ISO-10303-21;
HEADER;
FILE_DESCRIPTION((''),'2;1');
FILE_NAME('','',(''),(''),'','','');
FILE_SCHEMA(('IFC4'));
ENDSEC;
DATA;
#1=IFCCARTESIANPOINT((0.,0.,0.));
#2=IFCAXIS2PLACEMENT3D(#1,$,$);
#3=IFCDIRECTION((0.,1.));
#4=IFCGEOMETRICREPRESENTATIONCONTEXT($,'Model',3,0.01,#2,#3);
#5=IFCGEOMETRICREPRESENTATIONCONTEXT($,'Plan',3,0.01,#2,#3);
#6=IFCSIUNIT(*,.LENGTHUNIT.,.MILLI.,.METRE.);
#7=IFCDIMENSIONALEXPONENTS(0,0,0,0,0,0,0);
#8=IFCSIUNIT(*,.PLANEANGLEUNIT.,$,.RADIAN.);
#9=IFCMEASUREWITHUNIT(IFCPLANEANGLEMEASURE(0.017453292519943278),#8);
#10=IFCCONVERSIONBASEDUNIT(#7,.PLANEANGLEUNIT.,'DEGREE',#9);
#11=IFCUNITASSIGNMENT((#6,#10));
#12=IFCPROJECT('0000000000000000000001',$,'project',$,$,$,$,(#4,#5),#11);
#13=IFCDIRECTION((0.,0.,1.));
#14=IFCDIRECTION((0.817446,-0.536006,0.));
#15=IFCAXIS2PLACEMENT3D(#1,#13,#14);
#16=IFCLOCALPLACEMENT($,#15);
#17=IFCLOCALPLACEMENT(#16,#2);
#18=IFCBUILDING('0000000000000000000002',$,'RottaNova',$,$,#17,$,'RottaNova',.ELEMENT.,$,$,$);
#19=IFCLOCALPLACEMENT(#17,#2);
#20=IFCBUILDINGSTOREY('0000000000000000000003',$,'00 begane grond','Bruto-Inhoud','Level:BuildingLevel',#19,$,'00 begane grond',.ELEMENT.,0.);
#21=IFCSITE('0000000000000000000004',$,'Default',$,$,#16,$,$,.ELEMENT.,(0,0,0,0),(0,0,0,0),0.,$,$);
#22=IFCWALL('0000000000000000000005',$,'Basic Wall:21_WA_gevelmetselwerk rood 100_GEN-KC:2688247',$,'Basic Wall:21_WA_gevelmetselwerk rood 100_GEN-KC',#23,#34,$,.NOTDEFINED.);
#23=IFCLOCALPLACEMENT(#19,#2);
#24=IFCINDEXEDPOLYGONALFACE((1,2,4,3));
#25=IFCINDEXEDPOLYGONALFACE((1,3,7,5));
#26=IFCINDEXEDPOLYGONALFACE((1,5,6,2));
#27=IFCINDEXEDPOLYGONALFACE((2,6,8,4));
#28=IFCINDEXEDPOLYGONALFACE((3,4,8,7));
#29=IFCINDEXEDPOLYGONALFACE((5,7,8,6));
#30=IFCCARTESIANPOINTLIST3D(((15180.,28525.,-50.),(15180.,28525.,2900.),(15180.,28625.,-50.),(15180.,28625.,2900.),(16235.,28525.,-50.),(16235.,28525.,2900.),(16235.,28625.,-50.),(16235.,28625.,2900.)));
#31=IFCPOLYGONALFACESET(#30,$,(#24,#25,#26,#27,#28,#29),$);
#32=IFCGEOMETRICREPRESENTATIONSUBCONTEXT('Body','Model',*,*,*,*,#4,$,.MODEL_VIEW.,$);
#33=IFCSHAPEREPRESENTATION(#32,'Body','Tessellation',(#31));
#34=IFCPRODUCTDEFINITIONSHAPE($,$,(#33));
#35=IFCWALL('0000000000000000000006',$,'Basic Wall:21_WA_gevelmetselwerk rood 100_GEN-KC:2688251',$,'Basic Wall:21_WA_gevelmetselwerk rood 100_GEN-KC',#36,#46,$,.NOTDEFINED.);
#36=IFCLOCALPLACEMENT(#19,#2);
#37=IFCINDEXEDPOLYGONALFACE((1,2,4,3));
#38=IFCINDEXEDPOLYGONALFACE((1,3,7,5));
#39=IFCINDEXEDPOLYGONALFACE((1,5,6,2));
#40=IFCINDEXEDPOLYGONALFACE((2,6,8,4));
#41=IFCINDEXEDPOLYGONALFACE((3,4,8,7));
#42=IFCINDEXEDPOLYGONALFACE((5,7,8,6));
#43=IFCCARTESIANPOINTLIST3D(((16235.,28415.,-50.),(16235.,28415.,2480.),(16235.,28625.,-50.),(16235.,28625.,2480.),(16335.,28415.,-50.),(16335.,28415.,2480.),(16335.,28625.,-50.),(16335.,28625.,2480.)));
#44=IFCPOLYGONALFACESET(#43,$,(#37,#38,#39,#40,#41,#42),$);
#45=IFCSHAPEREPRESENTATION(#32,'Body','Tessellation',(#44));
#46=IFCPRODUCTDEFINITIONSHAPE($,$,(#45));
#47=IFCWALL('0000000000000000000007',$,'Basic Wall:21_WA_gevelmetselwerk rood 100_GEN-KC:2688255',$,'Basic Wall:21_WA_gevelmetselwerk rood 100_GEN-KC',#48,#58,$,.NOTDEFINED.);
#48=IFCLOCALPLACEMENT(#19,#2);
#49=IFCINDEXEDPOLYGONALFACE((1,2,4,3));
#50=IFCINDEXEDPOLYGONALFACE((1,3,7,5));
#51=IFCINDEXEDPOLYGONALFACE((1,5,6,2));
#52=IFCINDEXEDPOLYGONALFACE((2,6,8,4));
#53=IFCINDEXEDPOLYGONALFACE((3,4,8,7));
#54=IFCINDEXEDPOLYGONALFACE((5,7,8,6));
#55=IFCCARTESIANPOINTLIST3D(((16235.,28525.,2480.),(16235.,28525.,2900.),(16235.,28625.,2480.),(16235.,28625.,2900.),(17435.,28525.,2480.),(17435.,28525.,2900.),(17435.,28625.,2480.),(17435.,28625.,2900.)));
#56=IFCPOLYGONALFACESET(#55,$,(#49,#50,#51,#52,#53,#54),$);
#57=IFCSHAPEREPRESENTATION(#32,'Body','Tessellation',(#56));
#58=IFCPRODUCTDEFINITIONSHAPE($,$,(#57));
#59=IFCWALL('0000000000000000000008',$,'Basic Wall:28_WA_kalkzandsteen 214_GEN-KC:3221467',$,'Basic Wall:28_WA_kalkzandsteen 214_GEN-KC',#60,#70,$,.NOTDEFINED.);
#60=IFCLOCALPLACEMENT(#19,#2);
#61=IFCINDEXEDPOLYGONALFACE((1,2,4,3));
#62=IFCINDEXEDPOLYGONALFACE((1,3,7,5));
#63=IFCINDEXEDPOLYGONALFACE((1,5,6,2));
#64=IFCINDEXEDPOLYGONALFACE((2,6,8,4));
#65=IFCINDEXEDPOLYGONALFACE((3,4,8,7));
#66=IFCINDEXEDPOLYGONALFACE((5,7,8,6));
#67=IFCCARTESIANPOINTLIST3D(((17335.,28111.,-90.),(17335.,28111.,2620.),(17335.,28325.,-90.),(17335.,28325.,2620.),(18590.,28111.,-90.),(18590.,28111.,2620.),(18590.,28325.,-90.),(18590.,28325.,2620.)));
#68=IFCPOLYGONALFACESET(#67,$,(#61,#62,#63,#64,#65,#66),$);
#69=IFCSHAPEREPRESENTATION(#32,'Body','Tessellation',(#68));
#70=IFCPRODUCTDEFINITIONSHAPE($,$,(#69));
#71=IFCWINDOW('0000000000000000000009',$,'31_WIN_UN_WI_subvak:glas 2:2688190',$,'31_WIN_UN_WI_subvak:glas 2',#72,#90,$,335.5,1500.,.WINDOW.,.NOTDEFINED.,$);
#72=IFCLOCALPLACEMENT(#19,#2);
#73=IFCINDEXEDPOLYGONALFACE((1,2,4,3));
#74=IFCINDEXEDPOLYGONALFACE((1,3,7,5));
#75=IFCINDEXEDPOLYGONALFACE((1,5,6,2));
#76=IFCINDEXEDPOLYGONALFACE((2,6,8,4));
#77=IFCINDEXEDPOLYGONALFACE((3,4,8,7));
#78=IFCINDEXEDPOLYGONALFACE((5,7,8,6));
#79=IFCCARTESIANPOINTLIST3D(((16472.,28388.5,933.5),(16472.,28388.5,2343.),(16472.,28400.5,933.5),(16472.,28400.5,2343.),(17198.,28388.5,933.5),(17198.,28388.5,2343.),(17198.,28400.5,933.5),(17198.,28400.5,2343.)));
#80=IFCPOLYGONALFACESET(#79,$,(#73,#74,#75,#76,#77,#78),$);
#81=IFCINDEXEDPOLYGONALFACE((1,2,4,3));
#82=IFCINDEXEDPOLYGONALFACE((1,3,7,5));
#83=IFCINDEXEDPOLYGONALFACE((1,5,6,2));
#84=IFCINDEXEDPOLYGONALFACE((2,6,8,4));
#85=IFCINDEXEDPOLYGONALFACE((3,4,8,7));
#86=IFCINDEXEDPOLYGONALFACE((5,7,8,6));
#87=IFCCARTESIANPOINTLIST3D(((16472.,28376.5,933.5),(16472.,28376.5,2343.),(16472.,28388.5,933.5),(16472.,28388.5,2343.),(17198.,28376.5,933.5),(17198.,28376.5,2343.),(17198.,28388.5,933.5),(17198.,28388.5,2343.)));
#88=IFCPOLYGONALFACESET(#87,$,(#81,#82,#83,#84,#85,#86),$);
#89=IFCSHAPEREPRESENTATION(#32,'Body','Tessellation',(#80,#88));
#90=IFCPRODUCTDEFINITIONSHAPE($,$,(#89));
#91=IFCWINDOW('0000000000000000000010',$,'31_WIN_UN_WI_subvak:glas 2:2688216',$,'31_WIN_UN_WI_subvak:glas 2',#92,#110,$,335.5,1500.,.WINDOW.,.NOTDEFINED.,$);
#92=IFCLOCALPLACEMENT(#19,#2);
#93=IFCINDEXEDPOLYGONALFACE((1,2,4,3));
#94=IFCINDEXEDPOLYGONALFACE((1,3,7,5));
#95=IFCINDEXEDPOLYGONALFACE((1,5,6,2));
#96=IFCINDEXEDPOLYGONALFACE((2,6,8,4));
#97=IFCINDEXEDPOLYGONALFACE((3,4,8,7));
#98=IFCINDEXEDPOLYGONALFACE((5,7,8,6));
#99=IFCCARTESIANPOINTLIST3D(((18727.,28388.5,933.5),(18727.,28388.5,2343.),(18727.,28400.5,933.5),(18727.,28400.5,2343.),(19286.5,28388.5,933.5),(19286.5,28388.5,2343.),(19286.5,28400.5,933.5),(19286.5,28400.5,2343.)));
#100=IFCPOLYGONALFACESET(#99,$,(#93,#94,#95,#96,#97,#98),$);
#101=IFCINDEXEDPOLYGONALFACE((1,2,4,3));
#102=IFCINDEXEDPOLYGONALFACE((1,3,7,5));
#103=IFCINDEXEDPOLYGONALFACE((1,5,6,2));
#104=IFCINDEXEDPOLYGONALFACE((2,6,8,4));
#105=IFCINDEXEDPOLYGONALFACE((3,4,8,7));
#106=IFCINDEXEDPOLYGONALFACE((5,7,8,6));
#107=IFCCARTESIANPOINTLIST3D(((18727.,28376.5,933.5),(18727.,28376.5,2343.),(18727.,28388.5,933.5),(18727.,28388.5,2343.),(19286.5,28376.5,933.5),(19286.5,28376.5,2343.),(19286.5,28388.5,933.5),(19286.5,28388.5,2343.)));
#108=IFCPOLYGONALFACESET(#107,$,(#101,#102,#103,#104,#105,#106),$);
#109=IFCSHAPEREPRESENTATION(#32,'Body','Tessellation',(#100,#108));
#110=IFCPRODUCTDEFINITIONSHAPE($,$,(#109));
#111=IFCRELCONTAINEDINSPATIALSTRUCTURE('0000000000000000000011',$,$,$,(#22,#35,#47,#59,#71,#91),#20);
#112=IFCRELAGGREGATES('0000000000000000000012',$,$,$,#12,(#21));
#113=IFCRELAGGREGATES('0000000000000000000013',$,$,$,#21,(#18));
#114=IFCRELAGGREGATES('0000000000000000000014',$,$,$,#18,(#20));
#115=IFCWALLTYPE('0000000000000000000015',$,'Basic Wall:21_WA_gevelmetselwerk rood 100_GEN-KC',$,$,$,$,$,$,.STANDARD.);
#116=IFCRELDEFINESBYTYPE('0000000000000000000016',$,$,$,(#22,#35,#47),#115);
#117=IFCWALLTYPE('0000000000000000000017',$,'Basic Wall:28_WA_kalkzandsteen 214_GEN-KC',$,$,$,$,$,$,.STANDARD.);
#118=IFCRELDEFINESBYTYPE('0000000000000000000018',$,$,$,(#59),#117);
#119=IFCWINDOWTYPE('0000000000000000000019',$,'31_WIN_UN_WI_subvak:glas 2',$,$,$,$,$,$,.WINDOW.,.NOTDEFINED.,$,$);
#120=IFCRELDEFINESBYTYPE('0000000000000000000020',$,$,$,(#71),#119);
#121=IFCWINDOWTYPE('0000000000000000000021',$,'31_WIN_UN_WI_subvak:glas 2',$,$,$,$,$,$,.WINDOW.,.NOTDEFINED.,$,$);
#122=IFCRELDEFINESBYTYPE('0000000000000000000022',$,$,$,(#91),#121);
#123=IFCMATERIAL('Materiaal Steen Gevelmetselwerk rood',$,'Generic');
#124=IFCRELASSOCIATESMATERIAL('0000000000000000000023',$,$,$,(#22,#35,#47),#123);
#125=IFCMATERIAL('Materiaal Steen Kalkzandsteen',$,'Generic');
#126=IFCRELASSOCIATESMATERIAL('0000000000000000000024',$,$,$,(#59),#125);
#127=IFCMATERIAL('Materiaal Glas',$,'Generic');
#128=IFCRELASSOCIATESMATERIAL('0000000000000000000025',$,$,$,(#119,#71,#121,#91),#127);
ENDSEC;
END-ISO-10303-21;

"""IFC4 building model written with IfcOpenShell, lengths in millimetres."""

from ifc_helpers import new_model, entity, si_unit, converted_unit, direction, frame, origin, place, context, subcontext, project, spatial, indexed_curve, outline, extrude, source, transform, mapped, material, type_object, type_shapes, element, save


model = new_model("IFC4")

# Units and contexts
model_context = context("Model", 3, precision=0.01, world=origin(), true_north=direction((0.0, 1.0)))
plan_context = context("Plan", 3, precision=0.01, world=origin(), true_north=direction((0.0, 1.0)))
body_context = subcontext(model_context, "Body", "Model", "MODEL_VIEW")
ifc_project = project(units=[si_unit("LENGTHUNIT", "METRE", prefix="MILLI"), converted_unit("PLANEANGLEUNIT", "DEGREE", entity("IfcPlaneAngleMeasure", 0.017453292519943278), si_unit("PLANEANGLEUNIT", "RADIAN"), dimensions=[0, 0, 0, 0, 0, 0, 0])], contexts=[model_context, plan_context])

# Site, building, storey
site_placement = place(None, frame((0.0, 0.0, 0.0), z_axis=(0.0, 0.0, 1.0), x_axis=(0.817446, -0.536006, 0.0)))
site = spatial("IfcSite", under=ifc_project, at=site_placement, Name="Default", CompositionType="ELEMENT", RefLatitude=(0, 0, 0, 0), RefLongitude=(0, 0, 0, 0), RefElevation=0.0)
building_placement = place(site_placement, origin())
building = spatial("IfcBuilding", under=site, at=building_placement, Name="RottaNova", LongName="RottaNova", CompositionType="ELEMENT")
storey_placement = place(building_placement, origin())
storey = spatial("IfcBuildingStorey", under=building, at=storey_placement, Name="00 begane grond", Description="Bruto-Inhoud", ObjectType="Level:BuildingLevel", LongName="00 begane grond", CompositionType="ELEMENT", Elevation=0.0)

# Shared definitions
ifc_material_1 = material(Name="Materiaal Glas", Category="Generic")

# Walls
ifc_material_2 = material(Name="Materiaal Steen Gevelmetselwerk rood", Category="Generic")
wall_type_1 = type_object("IfcWallType", Name="Basic Wall:21_WA_gevelmetselwerk rood 100_GEN-KC", PredefinedType="STANDARD")
wall_1_placement = place(storey_placement, frame((16235.0, 28575.0, -50.0), z_axis=(0.0, 0.0, 1.0), x_axis=(-1.0, 0.0, 0.0)))
element("IfcWall", 1, at=wall_1_placement, inside=storey, type_object=wall_type_1, material=ifc_material_2, Name="Basic Wall:21_WA_gevelmetselwerk rood 100_GEN-KC:2688247", ObjectType="Basic Wall:21_WA_gevelmetselwerk rood 100_GEN-KC", PredefinedType="NOTDEFINED", context=body_context, shape_type="SweptSolid", body=[
    extrude(outline(indexed_curve([(1055.0, 50.0), (0.0, 50.0), (0.0, -50.0), (1055.0, -50.0), (1055.0, 50.0)], self_intersect=False)), origin(), (0.0, 0.0, 1.0), 2950.0),
])
wall_2_placement = place(storey_placement, frame((16285.0, 28415.0, -50.0), z_axis=(0.0, 0.0, 1.0), x_axis=(0.0, 1.0, 0.0)))
element("IfcWall", 2, at=wall_2_placement, inside=storey, type_object=wall_type_1, material=ifc_material_2, Name="Basic Wall:21_WA_gevelmetselwerk rood 100_GEN-KC:2688251", ObjectType="Basic Wall:21_WA_gevelmetselwerk rood 100_GEN-KC", PredefinedType="NOTDEFINED", context=body_context, shape_type="SweptSolid", body=[
    extrude(outline(indexed_curve([(210.0, 50.0), (0.0, 50.0), (0.0, -50.0), (210.0, -50.0), (210.0, 50.0)], self_intersect=False)), origin(), (0.0, 0.0, 1.0), 2530.0),
])
wall_3_placement = place(storey_placement, frame((17435.0, 28575.0, 2480.0), z_axis=(0.0, 0.0, 1.0), x_axis=(-1.0, 0.0, 0.0)))
element("IfcWall", 3, at=wall_3_placement, inside=storey, type_object=wall_type_1, material=ifc_material_2, Name="Basic Wall:21_WA_gevelmetselwerk rood 100_GEN-KC:2688255", ObjectType="Basic Wall:21_WA_gevelmetselwerk rood 100_GEN-KC", PredefinedType="NOTDEFINED", context=body_context, shape_type="SweptSolid", body=[
    extrude(outline(indexed_curve([(1200.0, 50.0), (0.0, 50.0), (0.0, -50.0), (1200.0, -50.0), (1200.0, 50.0)], self_intersect=False)), origin(), (0.0, 0.0, 1.0), 420.0),
])
ifc_material_3 = material(Name="Materiaal Steen Kalkzandsteen", Category="Generic")
wall_type_2 = type_object("IfcWallType", Name="Basic Wall:28_WA_kalkzandsteen 214_GEN-KC", PredefinedType="STANDARD")
wall_4_placement = place(storey_placement, frame((17335.0, 28218.0, -90.0)))
element("IfcWall", 4, at=wall_4_placement, inside=storey, type_object=wall_type_2, material=ifc_material_3, Name="Basic Wall:28_WA_kalkzandsteen 214_GEN-KC:3221467", ObjectType="Basic Wall:28_WA_kalkzandsteen 214_GEN-KC", PredefinedType="NOTDEFINED", context=body_context, shape_type="SweptSolid", body=[
    extrude(outline(indexed_curve([(1255.0, 107.0), (0.0, 107.0), (0.0, -107.0), (1255.0, -107.0), (1255.0, 107.0)], self_intersect=False)), origin(), (0.0, 0.0, 1.0), 2710.0),
])

# Windows
window_type_1 = type_object("IfcWindowType", Name="31_WIN_UN_WI_subvak:glas 2", PartitioningType="NOTDEFINED", PredefinedType="WINDOW", material=ifc_material_1)
shared_shape_1 = source(origin(), body_context, "Body", "SweptSolid", [
    extrude(outline(indexed_curve([(-363.0, -6.0), (363.0, -6.0), (363.0, 6.0), (-363.0, 6.0), (-363.0, -6.0)], self_intersect=False)), frame((0.0, -6.0, 0.0)), (0.0, 0.0, 1.0), 1409.5),
    extrude(outline(indexed_curve([(-363.0, -6.0), (363.0, -6.0), (363.0, 6.0), (-363.0, 6.0), (-363.0, -6.0)], self_intersect=False)), frame((0.0, 6.0, 0.0)), (0.0, 0.0, 1.0), 1409.5),
])
type_shapes(window_type_1, [shared_shape_1])
window_1_placement = place(storey_placement, frame((16835.0, 28388.5, 933.5), z_axis=(0.0, 0.0, 1.0), x_axis=(-1.0, 0.0, 0.0)))
element("IfcWindow", 5, at=window_1_placement, inside=storey, type_object=window_type_1, material=ifc_material_1, Name="31_WIN_UN_WI_subvak:glas 2:2688190", ObjectType="31_WIN_UN_WI_subvak:glas 2", OverallHeight=335.5, OverallWidth=1500.0, PartitioningType="NOTDEFINED", PredefinedType="WINDOW", context=body_context, shape_type="MappedRepresentation", body=[
    mapped(shared_shape_1, transform((0.0, 0.0, 0.0), scale=1.0)),
])
window_type_2 = type_object("IfcWindowType", Name="31_WIN_UN_WI_subvak:glas 2", PartitioningType="NOTDEFINED", PredefinedType="WINDOW", material=ifc_material_1)
shared_shape_2 = source(origin(), body_context, "Body", "SweptSolid", [
    extrude(outline(indexed_curve([(-6.0, -279.8), (6.0, -279.8), (6.0, 279.8), (-6.0, 279.8), (-6.0, -279.8)], self_intersect=False)), frame((0.0, 6.0, 0.0), z_axis=(0.0, 0.0, 1.0), x_axis=(0.0, -1.0, 0.0)), (0.0, 0.0, 1.0), 1409.5),
    extrude(outline(indexed_curve([(-6.0, -279.8), (6.0, -279.8), (6.0, 279.8), (-6.0, 279.8), (-6.0, -279.8)], self_intersect=False)), frame((0.0, -6.0, 0.0), z_axis=(0.0, 0.0, 1.0), x_axis=(0.0, -1.0, 0.0)), (0.0, 0.0, 1.0), 1409.5),
])
type_shapes(window_type_2, [shared_shape_2])
window_2_placement = place(storey_placement, frame((19006.8, 28388.5, 933.5)))
element("IfcWindow", 6, at=window_2_placement, inside=storey, type_object=window_type_2, material=ifc_material_1, Name="31_WIN_UN_WI_subvak:glas 2:2688216", ObjectType="31_WIN_UN_WI_subvak:glas 2", OverallHeight=335.5, OverallWidth=1500.0, PartitioningType="NOTDEFINED", PredefinedType="WINDOW", context=body_context, shape_type="MappedRepresentation", body=[
    mapped(shared_shape_2, transform((0.0, 0.0, 0.0), scale=1.0)),
])

save(model, "model.ifc")
